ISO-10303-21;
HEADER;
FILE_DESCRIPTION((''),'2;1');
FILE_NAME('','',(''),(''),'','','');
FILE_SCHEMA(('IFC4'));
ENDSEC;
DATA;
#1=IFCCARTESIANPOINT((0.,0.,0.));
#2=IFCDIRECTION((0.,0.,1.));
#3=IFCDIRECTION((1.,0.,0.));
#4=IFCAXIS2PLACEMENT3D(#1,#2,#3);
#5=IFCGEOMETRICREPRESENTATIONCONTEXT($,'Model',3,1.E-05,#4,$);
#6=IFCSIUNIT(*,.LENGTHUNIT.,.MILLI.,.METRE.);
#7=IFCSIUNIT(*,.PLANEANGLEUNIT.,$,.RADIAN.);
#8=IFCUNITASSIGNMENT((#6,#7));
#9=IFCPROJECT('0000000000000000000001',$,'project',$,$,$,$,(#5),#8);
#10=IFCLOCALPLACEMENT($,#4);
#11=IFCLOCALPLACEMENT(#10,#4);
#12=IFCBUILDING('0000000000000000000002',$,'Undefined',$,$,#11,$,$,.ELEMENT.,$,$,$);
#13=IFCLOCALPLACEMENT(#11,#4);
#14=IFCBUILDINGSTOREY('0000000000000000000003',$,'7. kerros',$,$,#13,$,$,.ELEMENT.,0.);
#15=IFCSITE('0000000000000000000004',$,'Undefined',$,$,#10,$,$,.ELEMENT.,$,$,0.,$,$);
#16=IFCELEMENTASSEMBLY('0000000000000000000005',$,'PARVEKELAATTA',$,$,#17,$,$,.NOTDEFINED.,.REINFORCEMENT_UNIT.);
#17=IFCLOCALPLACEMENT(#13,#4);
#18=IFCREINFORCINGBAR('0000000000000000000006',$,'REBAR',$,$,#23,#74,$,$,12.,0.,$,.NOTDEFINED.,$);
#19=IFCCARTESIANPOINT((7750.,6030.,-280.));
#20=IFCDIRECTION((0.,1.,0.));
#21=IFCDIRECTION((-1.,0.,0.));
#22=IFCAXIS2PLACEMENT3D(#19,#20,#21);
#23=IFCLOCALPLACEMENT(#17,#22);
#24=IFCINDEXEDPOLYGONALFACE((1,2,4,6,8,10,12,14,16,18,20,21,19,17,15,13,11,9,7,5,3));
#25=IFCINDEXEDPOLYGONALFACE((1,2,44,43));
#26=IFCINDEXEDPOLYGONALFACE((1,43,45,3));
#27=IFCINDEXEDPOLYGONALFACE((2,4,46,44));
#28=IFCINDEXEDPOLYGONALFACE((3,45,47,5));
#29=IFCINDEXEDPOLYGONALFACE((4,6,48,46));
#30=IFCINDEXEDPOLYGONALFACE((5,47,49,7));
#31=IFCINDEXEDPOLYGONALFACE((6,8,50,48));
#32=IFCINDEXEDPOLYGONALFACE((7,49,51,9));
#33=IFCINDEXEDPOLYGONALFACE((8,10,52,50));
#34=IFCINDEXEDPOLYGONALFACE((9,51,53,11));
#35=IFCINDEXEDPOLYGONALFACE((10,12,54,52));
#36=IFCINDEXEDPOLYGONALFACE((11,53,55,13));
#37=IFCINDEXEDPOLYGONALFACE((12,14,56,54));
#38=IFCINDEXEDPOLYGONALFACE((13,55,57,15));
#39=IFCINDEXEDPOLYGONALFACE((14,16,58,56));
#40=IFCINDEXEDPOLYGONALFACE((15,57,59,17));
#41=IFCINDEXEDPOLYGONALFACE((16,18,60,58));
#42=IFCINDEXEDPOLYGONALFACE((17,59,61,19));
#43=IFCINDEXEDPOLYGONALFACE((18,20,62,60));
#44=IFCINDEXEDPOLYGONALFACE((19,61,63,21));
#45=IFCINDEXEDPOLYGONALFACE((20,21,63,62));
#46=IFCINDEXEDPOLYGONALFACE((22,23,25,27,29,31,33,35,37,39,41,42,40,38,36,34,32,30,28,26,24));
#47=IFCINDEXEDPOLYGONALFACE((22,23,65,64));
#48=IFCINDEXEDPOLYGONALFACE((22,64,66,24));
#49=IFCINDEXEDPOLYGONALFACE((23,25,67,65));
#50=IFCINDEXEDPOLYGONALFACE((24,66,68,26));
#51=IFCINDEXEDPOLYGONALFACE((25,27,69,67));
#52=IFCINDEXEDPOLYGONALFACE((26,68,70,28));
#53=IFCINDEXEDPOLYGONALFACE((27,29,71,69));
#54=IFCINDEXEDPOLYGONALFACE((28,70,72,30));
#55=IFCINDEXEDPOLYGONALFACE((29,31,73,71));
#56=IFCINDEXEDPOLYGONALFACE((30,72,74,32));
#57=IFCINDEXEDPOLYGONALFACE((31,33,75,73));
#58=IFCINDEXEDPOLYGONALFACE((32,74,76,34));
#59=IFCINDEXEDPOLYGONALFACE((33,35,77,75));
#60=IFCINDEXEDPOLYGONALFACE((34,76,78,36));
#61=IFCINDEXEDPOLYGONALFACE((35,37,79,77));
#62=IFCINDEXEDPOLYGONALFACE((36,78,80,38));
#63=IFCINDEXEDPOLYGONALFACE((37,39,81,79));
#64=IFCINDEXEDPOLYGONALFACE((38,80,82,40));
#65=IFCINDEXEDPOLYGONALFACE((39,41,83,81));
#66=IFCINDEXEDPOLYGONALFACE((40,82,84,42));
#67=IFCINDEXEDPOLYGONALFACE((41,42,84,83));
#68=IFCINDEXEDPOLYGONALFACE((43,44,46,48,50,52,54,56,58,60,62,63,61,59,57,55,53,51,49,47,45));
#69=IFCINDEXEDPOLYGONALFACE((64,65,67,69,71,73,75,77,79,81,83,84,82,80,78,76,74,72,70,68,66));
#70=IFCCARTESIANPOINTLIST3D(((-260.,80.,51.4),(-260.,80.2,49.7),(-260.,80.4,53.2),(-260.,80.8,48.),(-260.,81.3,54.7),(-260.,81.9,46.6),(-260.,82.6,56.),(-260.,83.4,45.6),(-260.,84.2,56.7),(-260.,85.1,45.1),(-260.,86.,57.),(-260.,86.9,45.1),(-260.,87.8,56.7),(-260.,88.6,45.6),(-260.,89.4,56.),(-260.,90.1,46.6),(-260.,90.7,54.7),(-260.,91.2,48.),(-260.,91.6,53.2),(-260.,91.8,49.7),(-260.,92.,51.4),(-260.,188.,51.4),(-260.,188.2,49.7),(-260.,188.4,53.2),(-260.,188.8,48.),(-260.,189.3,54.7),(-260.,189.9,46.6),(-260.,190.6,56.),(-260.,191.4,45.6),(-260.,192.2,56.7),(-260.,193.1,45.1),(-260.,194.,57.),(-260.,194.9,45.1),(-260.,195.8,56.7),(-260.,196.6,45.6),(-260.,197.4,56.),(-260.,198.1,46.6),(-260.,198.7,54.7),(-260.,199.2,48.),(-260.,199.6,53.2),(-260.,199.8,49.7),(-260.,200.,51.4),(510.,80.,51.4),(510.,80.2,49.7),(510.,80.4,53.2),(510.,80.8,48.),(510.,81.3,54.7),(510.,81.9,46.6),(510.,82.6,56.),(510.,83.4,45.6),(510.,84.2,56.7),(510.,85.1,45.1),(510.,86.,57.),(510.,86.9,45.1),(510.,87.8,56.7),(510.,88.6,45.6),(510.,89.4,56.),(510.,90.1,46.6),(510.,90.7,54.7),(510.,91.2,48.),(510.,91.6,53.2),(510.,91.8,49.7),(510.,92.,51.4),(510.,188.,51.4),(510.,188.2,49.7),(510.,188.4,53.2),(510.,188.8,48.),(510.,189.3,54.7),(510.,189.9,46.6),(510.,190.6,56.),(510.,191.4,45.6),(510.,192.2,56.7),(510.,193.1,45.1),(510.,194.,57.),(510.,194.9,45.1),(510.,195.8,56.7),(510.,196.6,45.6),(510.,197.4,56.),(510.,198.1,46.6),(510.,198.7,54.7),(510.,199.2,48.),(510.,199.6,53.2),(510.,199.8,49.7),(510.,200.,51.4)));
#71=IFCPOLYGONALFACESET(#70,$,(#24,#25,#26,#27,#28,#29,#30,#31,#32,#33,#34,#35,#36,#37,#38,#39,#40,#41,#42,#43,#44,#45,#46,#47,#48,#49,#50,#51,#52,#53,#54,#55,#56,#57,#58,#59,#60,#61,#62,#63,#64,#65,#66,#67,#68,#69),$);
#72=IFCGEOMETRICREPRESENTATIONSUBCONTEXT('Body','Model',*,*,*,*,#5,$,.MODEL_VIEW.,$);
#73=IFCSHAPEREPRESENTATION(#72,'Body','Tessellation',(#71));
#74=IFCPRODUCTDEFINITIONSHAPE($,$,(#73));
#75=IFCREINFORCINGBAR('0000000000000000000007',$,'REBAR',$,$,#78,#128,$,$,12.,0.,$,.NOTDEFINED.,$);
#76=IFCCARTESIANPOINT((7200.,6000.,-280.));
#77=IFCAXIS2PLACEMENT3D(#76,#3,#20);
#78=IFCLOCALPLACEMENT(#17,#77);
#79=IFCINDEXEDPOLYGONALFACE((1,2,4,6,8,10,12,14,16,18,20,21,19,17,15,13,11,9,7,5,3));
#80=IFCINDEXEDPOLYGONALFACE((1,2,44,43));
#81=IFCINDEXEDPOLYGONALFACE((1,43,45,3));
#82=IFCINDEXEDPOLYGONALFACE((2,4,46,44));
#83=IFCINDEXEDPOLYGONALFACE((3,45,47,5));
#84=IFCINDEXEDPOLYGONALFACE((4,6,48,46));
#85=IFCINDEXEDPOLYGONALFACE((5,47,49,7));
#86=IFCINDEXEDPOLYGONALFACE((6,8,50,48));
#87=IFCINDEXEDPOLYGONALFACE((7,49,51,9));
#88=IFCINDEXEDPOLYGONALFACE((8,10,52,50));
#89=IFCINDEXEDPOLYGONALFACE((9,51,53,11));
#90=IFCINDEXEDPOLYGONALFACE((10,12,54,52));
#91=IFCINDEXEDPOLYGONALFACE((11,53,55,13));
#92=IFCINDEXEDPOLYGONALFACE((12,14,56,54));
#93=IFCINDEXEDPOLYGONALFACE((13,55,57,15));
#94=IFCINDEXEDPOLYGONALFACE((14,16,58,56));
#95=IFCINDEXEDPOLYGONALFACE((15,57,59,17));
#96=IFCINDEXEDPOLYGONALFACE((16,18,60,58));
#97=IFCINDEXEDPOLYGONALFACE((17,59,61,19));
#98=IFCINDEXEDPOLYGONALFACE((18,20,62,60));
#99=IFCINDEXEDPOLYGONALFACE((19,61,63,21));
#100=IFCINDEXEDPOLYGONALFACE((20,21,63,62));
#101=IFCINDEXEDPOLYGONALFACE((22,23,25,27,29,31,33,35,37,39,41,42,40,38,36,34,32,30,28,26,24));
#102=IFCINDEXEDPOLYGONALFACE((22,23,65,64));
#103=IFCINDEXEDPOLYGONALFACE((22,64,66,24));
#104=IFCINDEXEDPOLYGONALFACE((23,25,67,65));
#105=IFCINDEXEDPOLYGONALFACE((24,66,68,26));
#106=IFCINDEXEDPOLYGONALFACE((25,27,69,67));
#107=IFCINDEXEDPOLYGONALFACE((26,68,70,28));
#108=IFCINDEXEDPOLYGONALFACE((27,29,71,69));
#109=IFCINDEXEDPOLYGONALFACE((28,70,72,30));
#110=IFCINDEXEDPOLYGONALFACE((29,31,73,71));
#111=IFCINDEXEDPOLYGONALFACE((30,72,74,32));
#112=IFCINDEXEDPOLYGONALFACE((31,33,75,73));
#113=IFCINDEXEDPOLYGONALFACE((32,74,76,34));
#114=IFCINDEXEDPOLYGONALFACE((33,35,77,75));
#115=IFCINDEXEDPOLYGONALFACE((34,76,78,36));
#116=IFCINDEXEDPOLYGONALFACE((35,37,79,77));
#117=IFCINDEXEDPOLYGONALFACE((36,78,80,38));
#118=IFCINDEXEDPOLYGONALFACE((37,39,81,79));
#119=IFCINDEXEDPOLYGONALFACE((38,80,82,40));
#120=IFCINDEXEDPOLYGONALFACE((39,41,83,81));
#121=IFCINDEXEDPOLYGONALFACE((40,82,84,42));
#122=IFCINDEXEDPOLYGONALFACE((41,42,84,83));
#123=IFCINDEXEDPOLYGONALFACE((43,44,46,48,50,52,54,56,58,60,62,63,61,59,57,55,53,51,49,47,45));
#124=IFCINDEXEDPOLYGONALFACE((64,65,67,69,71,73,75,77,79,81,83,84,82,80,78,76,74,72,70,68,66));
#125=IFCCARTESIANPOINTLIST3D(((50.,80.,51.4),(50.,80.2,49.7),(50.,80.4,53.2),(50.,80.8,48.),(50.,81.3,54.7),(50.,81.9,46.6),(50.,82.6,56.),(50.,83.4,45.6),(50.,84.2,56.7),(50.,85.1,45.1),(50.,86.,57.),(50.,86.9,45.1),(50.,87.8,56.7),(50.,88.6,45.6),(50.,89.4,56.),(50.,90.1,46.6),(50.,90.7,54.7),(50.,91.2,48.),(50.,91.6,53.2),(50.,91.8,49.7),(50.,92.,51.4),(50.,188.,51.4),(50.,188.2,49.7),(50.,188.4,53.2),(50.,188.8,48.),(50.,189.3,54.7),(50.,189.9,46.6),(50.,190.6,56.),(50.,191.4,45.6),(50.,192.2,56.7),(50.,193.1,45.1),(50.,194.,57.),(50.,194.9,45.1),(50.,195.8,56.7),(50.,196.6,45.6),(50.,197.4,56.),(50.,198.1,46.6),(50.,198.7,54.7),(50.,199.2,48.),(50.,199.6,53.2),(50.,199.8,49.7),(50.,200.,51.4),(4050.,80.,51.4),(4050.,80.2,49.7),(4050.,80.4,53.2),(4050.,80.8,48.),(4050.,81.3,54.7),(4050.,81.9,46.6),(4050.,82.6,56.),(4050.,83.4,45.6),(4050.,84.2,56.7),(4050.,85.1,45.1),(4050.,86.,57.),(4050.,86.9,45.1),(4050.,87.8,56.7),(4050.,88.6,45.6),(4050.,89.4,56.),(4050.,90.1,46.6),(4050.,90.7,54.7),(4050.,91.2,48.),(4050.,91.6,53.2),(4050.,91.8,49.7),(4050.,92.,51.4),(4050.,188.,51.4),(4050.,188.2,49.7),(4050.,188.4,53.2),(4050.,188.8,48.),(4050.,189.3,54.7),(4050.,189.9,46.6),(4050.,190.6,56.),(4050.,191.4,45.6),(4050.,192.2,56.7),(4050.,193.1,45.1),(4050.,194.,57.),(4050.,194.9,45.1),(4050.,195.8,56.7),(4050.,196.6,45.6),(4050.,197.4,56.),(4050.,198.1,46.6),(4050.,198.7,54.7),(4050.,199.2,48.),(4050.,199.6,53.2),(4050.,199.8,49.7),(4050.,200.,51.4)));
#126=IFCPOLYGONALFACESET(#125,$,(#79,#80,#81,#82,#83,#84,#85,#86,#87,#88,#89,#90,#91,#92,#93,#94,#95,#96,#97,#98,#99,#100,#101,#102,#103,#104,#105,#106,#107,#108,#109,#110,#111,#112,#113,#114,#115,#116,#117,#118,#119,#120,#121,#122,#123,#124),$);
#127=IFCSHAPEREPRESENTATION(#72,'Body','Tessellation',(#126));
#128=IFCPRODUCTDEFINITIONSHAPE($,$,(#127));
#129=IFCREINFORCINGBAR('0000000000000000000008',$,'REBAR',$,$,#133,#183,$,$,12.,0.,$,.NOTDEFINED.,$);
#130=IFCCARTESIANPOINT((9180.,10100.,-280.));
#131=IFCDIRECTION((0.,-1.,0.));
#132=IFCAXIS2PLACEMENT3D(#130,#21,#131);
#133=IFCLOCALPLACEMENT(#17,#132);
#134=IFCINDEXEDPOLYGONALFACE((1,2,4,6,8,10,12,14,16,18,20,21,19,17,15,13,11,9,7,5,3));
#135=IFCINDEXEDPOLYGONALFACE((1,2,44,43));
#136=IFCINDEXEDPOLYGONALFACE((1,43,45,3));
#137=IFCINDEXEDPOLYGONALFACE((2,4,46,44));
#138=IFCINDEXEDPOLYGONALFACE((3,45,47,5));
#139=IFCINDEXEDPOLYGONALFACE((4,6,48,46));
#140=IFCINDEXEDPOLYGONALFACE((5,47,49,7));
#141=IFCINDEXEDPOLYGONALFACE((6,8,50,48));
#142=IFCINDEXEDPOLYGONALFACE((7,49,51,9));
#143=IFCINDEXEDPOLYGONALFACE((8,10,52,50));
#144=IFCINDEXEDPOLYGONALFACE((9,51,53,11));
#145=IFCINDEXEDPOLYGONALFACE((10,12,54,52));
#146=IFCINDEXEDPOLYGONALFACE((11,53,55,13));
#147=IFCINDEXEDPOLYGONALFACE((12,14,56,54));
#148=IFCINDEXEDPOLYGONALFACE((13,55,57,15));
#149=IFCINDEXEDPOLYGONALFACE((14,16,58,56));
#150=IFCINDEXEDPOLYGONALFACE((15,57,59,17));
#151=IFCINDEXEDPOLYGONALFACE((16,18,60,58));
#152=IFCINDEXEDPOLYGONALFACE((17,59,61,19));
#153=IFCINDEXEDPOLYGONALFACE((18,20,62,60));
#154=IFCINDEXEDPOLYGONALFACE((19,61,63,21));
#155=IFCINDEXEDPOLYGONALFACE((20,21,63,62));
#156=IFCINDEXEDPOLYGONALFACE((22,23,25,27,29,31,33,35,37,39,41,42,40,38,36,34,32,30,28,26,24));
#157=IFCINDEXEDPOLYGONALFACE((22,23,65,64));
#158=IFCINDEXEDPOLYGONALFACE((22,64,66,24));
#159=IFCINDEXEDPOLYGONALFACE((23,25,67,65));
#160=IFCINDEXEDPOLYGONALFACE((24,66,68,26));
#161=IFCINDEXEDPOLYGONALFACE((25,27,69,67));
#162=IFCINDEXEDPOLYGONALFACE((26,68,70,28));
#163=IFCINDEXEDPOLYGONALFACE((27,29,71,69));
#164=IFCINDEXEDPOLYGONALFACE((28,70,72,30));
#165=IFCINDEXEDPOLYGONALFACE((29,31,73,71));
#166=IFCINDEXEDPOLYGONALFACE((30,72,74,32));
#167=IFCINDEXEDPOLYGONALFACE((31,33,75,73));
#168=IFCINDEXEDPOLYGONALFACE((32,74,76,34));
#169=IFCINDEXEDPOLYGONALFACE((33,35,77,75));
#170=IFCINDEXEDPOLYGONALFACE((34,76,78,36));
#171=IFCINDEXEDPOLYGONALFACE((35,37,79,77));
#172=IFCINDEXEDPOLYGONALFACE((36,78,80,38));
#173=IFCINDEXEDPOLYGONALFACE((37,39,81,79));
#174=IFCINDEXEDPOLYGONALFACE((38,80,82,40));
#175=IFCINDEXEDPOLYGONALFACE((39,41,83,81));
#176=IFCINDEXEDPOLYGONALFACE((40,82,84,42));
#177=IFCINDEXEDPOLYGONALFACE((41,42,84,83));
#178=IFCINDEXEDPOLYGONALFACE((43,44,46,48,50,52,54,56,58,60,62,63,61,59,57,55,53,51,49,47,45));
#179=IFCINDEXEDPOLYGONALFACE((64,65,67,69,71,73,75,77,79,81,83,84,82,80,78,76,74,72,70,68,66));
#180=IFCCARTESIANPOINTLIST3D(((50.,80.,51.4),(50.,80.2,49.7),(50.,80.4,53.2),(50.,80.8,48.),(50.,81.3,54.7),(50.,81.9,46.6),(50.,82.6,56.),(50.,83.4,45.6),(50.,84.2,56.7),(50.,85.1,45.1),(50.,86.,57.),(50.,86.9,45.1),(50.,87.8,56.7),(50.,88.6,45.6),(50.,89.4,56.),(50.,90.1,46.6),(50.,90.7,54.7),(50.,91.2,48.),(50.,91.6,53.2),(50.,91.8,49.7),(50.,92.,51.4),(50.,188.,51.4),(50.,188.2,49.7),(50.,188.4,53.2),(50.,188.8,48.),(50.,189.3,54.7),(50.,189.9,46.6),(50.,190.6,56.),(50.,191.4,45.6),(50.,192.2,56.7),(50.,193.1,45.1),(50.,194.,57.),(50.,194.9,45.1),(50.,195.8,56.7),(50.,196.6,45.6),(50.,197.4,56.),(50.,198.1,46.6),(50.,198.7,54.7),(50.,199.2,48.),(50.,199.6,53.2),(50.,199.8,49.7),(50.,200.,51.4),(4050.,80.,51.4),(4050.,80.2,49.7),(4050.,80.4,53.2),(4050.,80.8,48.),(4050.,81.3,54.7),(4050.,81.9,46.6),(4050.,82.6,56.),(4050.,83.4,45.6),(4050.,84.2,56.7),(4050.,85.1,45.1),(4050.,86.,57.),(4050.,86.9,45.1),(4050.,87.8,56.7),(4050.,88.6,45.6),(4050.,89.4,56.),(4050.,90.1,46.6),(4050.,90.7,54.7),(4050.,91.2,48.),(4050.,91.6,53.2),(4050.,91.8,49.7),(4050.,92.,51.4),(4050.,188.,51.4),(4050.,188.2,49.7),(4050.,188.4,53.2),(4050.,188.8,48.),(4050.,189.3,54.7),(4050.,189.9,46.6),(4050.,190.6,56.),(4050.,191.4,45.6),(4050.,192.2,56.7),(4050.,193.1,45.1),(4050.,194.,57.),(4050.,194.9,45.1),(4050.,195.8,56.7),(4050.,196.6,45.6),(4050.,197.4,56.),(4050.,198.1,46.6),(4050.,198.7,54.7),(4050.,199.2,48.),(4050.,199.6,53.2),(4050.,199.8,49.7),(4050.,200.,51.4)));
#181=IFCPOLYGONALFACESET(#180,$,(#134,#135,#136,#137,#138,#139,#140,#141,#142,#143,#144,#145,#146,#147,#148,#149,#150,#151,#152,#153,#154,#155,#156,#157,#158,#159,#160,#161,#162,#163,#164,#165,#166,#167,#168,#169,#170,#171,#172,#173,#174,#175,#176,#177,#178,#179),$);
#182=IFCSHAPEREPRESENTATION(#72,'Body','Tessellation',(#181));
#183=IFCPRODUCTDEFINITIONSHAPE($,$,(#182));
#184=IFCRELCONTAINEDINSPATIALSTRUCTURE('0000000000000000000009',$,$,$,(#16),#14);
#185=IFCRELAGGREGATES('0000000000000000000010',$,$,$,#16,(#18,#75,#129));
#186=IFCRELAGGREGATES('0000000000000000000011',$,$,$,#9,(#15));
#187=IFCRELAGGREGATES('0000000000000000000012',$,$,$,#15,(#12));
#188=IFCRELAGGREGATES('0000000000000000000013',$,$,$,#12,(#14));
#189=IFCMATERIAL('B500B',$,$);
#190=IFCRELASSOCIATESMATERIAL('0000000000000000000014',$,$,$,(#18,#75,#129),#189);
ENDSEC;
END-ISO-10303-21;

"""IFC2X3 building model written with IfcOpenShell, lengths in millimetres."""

from ifc_helpers import new_model, entity, si_unit, frame, origin_with_axes, place, context, subcontext, project, spatial, source, transform, mapped, material, element, aggregate, save


model = new_model("IFC2X3")

# Units and contexts
model_context = context("Model", 3, precision=1e-05, world=origin_with_axes())
body_context = subcontext(model_context, "Body", "Model", "MODEL_VIEW")
ifc_project = project(units=[si_unit("LENGTHUNIT", "METRE", prefix="MILLI"), si_unit("PLANEANGLEUNIT", "RADIAN")], contexts=[model_context])

# Site, building, storey
site_placement = place(None, origin_with_axes())
site = spatial("IfcSite", under=ifc_project, at=site_placement, Name="Undefined", CompositionType="ELEMENT", RefElevation=0.0)
building_placement = place(site_placement, origin_with_axes())
building = spatial("IfcBuilding", under=site, at=building_placement, Name="Undefined", CompositionType="ELEMENT")
storey_placement = place(building_placement, origin_with_axes())
storey = spatial("IfcBuildingStorey", under=building, at=storey_placement, Name="7. kerros", CompositionType="ELEMENT", Elevation=0.0)

# Element assembly, reinforcing bars
assembly_placement = place(storey_placement, origin_with_axes())
assembly = element("IfcElementAssembly", 1, at=assembly_placement, inside=storey, Name="PARVEKELAATTA", AssemblyPlace="NOTDEFINED", PredefinedType="REINFORCEMENT_UNIT")
ifc_material_1 = material(Name="B500B")
shared_shape_1 = source(origin_with_axes(), body_context, "Body", "AdvancedSweptSolid", [
    entity("IfcSweptDiskSolid", entity("IfcTrimmedCurve", entity("IfcLine", entity("IfcCartesianPoint", [0.0, 0.0, 0.0]), entity("IfcVector", entity("IfcDirection", [1.0, 0.0, 0.0]), 1.0)), [entity("IfcParameterValue", 0.0)], [entity("IfcParameterValue", 770.0)], True, "PARAMETER"), 6.0, None, 0.0, 770.0),
])
shared_shape_2 = source(origin_with_axes(), body_context, "Body", "AdvancedSweptSolid", [
    entity("IfcSweptDiskSolid", entity("IfcTrimmedCurve", entity("IfcLine", entity("IfcCartesianPoint", [0.0, 0.0, 0.0]), entity("IfcVector", entity("IfcDirection", [1.0, 0.0, 0.0]), 1.0)), [entity("IfcParameterValue", 0.0)], [entity("IfcParameterValue", 770.0)], True, "PARAMETER"), 6.0, None, 0.0, 770.0),
])
reinforcing_bar_1_placement = place(assembly_placement, frame((7750.0, 6030.0, -280.0), z_axis=(0.0, 1.0, 0.0), x_axis=(-1.0, 0.0, 0.0)))
reinforcing_bar_1 = element("IfcReinforcingBar", 2, at=reinforcing_bar_1_placement, material=ifc_material_1, Name="REBAR", BarRole="NOTDEFINED", CrossSectionArea=0.0, NominalDiameter=12.0, context=body_context, shape_type="MappedRepresentation", body=[
    mapped(shared_shape_1, transform((-260.0, 86.0, 51.0))),
    mapped(shared_shape_2, transform((-260.0, 194.0, 51.0))),
])
shared_shape_3 = source(origin_with_axes(), body_context, "Body", "AdvancedSweptSolid", [
    entity("IfcSweptDiskSolid", entity("IfcTrimmedCurve", entity("IfcLine", entity("IfcCartesianPoint", [0.0, 0.0, 0.0]), entity("IfcVector", entity("IfcDirection", [1.0, 0.0, 0.0]), 1.0)), [entity("IfcParameterValue", 0.0)], [entity("IfcParameterValue", 4000.0)], True, "PARAMETER"), 6.0, None, 0.0, 4000.0),
])
shared_shape_4 = source(origin_with_axes(), body_context, "Body", "AdvancedSweptSolid", [
    entity("IfcSweptDiskSolid", entity("IfcTrimmedCurve", entity("IfcLine", entity("IfcCartesianPoint", [0.0, 0.0, 0.0]), entity("IfcVector", entity("IfcDirection", [1.0, 0.0, 0.0]), 1.0)), [entity("IfcParameterValue", 0.0)], [entity("IfcParameterValue", 4000.0)], True, "PARAMETER"), 6.0, None, 0.0, 4000.0),
])
reinforcing_bar_2_placement = place(assembly_placement, frame((7200.0, 6000.0, -280.0), z_axis=(1.0, 0.0, 0.0), x_axis=(0.0, 1.0, 0.0)))
reinforcing_bar_2 = element("IfcReinforcingBar", 3, at=reinforcing_bar_2_placement, material=ifc_material_1, Name="REBAR", BarRole="NOTDEFINED", CrossSectionArea=0.0, NominalDiameter=12.0, context=body_context, shape_type="MappedRepresentation", body=[
    mapped(shared_shape_3, transform((50.0, 86.0, 51.0))),
    mapped(shared_shape_4, transform((50.0, 194.0, 51.0))),
])
shared_shape_5 = source(origin_with_axes(), body_context, "Body", "AdvancedSweptSolid", [
    entity("IfcSweptDiskSolid", entity("IfcTrimmedCurve", entity("IfcLine", entity("IfcCartesianPoint", [0.0, 0.0, 0.0]), entity("IfcVector", entity("IfcDirection", [1.0, 0.0, 0.0]), 1.0)), [entity("IfcParameterValue", 0.0)], [entity("IfcParameterValue", 4000.0)], True, "PARAMETER"), 6.0, None, 0.0, 4000.0),
])
shared_shape_6 = source(origin_with_axes(), body_context, "Body", "AdvancedSweptSolid", [
    entity("IfcSweptDiskSolid", entity("IfcTrimmedCurve", entity("IfcLine", entity("IfcCartesianPoint", [0.0, 0.0, 0.0]), entity("IfcVector", entity("IfcDirection", [1.0, 0.0, 0.0]), 1.0)), [entity("IfcParameterValue", 0.0)], [entity("IfcParameterValue", 4000.0)], True, "PARAMETER"), 6.0, None, 0.0, 4000.0),
])
reinforcing_bar_3_placement = place(assembly_placement, frame((9180.0, 10100.0, -280.0), z_axis=(-1.0, 0.0, 0.0), x_axis=(0.0, -1.0, 0.0)))
reinforcing_bar_3 = element("IfcReinforcingBar", 4, at=reinforcing_bar_3_placement, material=ifc_material_1, Name="REBAR", BarRole="NOTDEFINED", CrossSectionArea=0.0, NominalDiameter=12.0, context=body_context, shape_type="MappedRepresentation", body=[
    mapped(shared_shape_5, transform((50.0, 86.0, 51.0))),
    mapped(shared_shape_6, transform((50.0, 194.0, 51.0))),
])
aggregate(assembly, [reinforcing_bar_1, reinforcing_bar_2, reinforcing_bar_3])

save(model, "model.ifc")
